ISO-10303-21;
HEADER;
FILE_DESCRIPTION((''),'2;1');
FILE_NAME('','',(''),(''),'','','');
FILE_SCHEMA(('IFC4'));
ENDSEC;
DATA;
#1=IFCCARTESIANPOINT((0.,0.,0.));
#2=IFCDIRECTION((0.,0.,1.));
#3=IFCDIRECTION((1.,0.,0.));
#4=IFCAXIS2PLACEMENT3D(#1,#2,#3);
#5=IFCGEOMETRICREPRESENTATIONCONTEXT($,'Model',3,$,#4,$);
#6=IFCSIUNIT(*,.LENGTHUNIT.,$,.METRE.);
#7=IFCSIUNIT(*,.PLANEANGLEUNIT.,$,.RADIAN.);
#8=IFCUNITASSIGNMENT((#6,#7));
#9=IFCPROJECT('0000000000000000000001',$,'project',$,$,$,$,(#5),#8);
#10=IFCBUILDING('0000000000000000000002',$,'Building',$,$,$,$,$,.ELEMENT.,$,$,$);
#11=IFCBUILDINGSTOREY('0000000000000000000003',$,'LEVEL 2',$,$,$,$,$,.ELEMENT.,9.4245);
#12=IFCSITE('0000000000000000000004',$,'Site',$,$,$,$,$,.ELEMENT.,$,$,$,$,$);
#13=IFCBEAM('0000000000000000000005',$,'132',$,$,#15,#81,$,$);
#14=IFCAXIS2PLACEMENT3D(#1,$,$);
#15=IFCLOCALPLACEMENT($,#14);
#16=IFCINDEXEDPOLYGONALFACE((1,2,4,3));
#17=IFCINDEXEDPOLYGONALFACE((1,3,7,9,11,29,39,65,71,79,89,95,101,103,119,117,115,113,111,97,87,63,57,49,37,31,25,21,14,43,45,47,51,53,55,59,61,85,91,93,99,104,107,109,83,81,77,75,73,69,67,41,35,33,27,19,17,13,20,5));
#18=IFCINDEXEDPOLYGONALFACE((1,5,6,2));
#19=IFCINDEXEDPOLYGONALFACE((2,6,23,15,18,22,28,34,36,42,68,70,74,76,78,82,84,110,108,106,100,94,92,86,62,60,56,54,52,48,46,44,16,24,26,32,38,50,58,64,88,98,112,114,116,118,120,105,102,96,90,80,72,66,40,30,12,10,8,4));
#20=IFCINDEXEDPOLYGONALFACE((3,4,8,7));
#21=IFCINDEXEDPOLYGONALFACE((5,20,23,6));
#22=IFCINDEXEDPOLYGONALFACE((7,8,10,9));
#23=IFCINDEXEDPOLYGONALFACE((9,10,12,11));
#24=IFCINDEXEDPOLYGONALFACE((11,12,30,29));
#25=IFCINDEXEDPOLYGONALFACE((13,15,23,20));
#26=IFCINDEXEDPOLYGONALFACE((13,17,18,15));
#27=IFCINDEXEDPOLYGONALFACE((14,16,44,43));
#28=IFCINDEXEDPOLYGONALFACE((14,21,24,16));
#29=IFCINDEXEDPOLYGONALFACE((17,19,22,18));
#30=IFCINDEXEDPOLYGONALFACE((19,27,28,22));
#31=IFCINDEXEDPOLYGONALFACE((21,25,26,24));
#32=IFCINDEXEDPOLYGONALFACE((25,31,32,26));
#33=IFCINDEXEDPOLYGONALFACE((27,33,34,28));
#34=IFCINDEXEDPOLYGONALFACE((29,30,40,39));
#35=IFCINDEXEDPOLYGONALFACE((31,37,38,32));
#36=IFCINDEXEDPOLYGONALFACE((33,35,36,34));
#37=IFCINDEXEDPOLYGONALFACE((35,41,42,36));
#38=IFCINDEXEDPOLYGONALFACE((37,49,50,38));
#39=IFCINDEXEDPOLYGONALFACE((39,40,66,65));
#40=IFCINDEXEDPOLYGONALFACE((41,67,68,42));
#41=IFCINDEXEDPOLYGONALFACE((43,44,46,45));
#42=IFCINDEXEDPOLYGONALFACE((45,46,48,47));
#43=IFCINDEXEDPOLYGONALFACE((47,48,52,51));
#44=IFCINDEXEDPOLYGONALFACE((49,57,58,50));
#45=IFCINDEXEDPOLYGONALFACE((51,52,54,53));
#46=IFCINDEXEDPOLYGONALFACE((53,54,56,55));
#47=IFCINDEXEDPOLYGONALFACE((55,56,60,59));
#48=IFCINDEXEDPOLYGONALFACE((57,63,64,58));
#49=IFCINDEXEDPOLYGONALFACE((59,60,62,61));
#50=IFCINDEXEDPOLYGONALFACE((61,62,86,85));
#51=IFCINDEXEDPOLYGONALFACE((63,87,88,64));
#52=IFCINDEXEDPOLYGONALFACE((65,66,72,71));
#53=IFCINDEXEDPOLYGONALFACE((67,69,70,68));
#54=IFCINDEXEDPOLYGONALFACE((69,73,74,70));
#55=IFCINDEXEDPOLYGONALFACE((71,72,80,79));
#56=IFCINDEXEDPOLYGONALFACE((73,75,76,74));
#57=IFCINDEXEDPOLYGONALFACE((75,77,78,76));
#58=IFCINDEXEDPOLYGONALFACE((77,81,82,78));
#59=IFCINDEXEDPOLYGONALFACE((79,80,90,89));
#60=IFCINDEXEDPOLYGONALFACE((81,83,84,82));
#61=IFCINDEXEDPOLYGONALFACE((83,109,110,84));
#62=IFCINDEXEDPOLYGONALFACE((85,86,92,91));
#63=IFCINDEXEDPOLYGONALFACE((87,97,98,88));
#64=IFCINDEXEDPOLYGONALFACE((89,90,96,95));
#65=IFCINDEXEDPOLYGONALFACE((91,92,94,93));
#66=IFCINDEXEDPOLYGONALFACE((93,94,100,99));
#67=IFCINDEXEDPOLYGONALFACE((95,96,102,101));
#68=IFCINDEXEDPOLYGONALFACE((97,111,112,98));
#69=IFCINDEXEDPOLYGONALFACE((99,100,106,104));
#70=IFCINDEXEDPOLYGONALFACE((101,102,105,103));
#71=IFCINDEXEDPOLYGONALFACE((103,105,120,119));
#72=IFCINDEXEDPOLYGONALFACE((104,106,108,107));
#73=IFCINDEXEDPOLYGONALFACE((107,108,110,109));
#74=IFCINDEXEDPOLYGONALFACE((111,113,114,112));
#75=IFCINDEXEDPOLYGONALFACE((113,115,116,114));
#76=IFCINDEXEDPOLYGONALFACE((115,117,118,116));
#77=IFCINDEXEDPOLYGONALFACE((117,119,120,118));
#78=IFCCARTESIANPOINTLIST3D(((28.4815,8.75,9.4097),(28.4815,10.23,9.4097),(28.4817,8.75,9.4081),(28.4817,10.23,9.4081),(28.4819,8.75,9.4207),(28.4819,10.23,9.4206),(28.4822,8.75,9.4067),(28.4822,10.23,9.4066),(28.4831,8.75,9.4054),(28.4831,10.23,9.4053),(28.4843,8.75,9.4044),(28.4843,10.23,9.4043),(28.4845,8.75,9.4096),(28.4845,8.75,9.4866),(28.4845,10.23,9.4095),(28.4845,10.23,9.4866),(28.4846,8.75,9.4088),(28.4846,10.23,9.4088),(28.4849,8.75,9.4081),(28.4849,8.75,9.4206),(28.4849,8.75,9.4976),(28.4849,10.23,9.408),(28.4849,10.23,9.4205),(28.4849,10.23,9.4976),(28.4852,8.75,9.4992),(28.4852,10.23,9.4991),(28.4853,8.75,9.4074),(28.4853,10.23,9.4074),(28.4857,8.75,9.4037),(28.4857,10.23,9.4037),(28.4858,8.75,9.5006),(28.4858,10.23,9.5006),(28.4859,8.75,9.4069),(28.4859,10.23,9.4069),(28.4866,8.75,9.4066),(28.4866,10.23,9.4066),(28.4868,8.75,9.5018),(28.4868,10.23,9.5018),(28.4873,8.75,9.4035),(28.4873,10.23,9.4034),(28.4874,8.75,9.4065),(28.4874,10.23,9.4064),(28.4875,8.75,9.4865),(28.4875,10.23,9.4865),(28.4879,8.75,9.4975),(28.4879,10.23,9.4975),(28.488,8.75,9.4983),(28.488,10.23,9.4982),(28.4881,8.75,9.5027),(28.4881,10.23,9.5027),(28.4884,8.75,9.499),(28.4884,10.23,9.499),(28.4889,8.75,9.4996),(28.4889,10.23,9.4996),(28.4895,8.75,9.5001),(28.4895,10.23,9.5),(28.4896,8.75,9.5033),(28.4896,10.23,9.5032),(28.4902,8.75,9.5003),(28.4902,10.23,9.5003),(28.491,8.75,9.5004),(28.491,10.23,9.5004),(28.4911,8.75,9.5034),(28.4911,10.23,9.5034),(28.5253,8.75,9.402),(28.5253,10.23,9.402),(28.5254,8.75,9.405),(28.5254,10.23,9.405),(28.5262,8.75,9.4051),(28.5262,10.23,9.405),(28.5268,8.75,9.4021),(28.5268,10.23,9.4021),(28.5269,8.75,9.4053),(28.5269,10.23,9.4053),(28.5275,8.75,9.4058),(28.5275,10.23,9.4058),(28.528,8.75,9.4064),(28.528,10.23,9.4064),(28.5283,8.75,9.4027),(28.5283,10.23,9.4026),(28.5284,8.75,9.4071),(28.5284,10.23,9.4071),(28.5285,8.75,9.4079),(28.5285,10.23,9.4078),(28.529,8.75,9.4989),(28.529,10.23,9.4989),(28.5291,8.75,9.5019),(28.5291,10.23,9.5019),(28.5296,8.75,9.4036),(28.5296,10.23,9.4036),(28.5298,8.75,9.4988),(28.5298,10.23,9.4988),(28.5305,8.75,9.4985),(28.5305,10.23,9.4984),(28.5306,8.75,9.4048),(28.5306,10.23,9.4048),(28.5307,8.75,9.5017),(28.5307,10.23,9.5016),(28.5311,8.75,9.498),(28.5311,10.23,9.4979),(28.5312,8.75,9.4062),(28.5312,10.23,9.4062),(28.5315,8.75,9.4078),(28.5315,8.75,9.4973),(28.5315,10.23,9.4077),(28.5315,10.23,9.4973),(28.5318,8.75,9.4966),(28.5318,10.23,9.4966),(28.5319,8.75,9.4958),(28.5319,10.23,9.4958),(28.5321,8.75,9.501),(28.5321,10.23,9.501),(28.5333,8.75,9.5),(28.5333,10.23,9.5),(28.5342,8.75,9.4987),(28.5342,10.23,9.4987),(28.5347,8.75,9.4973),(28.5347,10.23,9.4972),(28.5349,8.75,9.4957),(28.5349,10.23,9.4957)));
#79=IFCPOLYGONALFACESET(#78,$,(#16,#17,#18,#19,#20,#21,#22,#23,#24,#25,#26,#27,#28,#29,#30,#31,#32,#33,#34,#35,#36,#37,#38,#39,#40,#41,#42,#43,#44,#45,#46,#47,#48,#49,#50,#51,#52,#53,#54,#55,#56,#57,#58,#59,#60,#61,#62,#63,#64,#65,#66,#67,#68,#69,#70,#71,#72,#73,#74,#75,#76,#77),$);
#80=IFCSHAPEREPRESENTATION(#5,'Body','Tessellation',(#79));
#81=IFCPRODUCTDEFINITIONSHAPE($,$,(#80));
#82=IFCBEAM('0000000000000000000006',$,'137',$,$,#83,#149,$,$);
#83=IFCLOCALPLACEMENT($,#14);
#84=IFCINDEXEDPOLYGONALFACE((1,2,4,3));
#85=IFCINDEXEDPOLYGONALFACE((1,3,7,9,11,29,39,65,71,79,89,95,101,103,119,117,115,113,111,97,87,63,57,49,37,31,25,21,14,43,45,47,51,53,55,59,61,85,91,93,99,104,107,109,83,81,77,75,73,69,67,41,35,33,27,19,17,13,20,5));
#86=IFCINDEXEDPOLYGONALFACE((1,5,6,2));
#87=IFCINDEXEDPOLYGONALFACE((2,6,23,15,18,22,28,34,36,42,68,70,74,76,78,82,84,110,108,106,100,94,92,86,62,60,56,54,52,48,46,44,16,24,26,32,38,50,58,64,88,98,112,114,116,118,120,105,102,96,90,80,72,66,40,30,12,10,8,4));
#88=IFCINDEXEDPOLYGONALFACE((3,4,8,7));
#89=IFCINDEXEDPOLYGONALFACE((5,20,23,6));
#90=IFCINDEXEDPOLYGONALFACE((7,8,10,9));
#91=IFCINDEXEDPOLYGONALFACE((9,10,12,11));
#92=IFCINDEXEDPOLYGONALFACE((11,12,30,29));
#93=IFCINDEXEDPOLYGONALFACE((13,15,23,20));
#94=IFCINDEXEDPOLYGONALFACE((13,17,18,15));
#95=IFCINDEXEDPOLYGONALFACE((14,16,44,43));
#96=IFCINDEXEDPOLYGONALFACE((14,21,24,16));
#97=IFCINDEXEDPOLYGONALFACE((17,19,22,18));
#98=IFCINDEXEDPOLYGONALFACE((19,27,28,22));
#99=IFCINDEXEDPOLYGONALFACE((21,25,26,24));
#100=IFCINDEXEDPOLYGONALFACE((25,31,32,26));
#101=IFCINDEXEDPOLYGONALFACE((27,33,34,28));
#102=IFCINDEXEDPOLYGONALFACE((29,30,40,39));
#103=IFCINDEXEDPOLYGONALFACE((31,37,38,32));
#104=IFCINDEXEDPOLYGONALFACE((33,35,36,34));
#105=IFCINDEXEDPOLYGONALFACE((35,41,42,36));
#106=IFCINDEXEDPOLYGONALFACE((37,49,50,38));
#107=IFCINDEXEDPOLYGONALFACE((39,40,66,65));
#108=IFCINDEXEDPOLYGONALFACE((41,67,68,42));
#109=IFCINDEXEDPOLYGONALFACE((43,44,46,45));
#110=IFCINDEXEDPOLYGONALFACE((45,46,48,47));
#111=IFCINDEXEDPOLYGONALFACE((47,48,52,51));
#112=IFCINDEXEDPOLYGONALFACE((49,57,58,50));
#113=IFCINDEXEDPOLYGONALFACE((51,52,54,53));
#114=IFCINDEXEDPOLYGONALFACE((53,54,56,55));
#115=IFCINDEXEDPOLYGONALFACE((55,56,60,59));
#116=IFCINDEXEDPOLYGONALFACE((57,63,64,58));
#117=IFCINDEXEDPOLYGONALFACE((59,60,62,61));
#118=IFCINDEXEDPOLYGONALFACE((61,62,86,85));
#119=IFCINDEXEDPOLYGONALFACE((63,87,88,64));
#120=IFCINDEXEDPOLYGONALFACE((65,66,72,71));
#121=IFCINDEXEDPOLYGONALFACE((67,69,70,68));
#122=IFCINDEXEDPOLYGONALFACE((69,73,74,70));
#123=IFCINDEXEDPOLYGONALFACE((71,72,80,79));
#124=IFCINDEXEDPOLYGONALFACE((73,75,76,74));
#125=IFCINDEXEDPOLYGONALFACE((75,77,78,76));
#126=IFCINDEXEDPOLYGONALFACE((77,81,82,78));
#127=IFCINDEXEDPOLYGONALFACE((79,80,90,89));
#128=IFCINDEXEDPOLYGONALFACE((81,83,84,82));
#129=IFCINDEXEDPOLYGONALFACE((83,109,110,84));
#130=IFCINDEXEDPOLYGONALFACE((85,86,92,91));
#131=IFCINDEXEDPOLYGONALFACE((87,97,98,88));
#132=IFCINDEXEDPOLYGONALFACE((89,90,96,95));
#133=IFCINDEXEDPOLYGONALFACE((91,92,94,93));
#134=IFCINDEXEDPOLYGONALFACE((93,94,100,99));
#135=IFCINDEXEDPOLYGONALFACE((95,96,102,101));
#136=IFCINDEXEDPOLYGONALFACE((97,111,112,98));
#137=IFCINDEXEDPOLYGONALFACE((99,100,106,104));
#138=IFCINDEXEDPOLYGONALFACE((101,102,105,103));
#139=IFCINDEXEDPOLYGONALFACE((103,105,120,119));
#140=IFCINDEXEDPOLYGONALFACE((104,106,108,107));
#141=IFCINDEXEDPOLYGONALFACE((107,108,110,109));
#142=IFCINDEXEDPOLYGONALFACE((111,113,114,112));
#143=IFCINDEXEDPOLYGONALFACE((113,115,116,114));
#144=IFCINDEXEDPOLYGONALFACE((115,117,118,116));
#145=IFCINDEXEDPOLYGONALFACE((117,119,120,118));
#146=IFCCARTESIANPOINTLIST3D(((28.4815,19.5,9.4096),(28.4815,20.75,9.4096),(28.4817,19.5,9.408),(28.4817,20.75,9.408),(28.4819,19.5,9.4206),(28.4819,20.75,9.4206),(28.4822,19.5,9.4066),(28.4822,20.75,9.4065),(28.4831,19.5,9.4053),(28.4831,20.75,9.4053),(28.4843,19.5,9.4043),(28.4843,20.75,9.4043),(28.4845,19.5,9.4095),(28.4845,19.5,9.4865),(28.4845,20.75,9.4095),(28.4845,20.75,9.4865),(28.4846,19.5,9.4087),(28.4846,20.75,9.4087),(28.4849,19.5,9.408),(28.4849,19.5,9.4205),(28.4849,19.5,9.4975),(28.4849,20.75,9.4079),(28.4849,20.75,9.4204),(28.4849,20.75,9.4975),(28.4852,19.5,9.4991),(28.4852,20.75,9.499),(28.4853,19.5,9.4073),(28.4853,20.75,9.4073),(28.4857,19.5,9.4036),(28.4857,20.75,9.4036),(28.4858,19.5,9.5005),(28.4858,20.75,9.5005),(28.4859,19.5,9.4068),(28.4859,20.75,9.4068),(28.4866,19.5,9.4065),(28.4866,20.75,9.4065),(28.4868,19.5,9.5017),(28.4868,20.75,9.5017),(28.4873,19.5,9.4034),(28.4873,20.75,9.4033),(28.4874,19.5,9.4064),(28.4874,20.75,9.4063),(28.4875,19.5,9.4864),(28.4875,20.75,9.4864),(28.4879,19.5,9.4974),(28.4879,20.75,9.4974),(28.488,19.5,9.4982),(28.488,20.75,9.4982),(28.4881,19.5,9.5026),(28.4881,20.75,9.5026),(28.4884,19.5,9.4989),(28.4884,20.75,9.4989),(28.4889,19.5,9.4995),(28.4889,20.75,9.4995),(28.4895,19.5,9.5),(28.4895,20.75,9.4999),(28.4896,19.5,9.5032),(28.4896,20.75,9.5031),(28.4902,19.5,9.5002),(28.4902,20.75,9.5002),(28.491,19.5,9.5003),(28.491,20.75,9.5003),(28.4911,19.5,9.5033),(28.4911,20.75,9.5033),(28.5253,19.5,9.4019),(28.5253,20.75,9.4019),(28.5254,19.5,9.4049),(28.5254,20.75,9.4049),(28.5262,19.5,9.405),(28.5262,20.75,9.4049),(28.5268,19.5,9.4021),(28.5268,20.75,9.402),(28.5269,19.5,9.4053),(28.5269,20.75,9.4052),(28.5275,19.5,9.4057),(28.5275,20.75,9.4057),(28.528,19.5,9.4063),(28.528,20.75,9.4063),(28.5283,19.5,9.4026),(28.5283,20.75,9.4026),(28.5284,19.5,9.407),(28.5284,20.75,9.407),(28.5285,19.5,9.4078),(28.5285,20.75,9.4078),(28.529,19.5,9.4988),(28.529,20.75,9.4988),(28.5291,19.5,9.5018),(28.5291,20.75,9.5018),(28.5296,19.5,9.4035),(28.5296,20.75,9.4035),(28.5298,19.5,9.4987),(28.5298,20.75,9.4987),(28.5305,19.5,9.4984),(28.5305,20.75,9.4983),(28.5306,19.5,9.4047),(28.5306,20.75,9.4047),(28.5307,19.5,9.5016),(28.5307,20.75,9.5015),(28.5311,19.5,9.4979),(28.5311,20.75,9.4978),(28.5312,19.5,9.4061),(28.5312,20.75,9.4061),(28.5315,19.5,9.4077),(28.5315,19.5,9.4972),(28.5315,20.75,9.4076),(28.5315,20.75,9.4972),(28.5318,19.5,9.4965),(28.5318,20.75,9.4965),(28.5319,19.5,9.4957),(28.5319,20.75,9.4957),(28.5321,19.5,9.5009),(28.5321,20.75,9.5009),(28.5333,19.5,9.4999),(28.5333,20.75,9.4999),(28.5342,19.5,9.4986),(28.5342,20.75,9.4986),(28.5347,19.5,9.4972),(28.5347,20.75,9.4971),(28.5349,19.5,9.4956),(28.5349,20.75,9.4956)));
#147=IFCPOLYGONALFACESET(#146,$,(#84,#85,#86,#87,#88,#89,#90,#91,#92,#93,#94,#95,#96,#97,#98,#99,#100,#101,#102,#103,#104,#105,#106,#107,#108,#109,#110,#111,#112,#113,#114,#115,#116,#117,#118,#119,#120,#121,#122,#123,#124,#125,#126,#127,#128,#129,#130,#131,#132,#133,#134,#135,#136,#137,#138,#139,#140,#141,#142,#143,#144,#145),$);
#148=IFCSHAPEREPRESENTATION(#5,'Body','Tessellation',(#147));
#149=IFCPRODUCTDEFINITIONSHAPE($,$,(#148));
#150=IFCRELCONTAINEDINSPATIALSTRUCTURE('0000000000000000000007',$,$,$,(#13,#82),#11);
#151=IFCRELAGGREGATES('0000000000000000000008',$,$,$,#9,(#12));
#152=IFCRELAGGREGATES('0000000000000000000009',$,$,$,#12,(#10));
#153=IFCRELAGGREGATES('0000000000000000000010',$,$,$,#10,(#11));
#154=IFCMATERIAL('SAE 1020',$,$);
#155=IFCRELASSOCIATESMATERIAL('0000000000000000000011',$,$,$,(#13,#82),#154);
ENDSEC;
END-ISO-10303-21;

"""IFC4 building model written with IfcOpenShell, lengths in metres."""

from ifc_helpers import new_model, si_unit, frame, origin_with_axes, origin_2d_with_axis, place, context, project, spatial, c_section, extrude, material, material_profile, profile_set, profile_usage, element, save


model = new_model("IFC4")

# Units and contexts
model_context = context("Model", 3, world=origin_with_axes())
ifc_project = project(units=[si_unit("LENGTHUNIT", "METRE"), si_unit("PLANEANGLEUNIT", "RADIAN")], contexts=[model_context])

# Site, building, storey
site = spatial("IfcSite", under=ifc_project, Name="Site", CompositionType="ELEMENT")
building = spatial("IfcBuilding", under=site, Name="Building", CompositionType="ELEMENT")
storey = spatial("IfcBuildingStorey", under=building, Name="LEVEL 2", CompositionType="ELEMENT", Elevation=9.4245)

# Beams
ifc_material = material(Name="SAE 1020")
ifc_material_profile_1 = material_profile(ifc_material, c_section(Depth=0.1, Width=0.05, WallThickness=0.003, Girth=0.017, InternalFilletRadius=0.003, at=origin_2d_with_axis()))
ifc_profile_set_1 = profile_set([ifc_material_profile_1])
ifc_profile_usage_1 = profile_usage(ifc_profile_set_1, cardinal=10)
beam_1_placement = place(None, frame((28.5082, 8.75, 9.4527), z_axis=(0.0, 1.0, -0.00003), x_axis=(-0.999256, 0.000001, 0.038562)))
element("IfcBeam", 1, at=beam_1_placement, inside=storey, material=ifc_profile_usage_1, Name="132", context=model_context, shape_type="SweptSolid", body=[
    extrude(c_section(Depth=0.1, Width=0.05, WallThickness=0.003, Girth=0.017, InternalFilletRadius=0.003, at=origin_2d_with_axis()), origin_with_axes(), (0.0, 0.0, 1.0), 1.48),
])
ifc_material_profile_2 = material_profile(ifc_material, c_section(Depth=0.1, Width=0.05, WallThickness=0.003, Girth=0.017, InternalFilletRadius=0.003, at=origin_2d_with_axis()))
ifc_profile_set_2 = profile_set([ifc_material_profile_2])
ifc_profile_usage_2 = profile_usage(ifc_profile_set_2, cardinal=10)
beam_2_placement = place(None, frame((28.5082, 19.5, 9.4526), z_axis=(0.0, 1.0, -0.00003), x_axis=(-0.999256, 0.000001, 0.038562)))
element("IfcBeam", 2, at=beam_2_placement, inside=storey, material=ifc_profile_usage_2, Name="137", context=model_context, shape_type="SweptSolid", body=[
    extrude(c_section(Depth=0.1, Width=0.05, WallThickness=0.003, Girth=0.017, InternalFilletRadius=0.003, at=origin_2d_with_axis()), origin_with_axes(), (0.0, 0.0, 1.0), 1.25),
])

save(model, "model.ifc")
